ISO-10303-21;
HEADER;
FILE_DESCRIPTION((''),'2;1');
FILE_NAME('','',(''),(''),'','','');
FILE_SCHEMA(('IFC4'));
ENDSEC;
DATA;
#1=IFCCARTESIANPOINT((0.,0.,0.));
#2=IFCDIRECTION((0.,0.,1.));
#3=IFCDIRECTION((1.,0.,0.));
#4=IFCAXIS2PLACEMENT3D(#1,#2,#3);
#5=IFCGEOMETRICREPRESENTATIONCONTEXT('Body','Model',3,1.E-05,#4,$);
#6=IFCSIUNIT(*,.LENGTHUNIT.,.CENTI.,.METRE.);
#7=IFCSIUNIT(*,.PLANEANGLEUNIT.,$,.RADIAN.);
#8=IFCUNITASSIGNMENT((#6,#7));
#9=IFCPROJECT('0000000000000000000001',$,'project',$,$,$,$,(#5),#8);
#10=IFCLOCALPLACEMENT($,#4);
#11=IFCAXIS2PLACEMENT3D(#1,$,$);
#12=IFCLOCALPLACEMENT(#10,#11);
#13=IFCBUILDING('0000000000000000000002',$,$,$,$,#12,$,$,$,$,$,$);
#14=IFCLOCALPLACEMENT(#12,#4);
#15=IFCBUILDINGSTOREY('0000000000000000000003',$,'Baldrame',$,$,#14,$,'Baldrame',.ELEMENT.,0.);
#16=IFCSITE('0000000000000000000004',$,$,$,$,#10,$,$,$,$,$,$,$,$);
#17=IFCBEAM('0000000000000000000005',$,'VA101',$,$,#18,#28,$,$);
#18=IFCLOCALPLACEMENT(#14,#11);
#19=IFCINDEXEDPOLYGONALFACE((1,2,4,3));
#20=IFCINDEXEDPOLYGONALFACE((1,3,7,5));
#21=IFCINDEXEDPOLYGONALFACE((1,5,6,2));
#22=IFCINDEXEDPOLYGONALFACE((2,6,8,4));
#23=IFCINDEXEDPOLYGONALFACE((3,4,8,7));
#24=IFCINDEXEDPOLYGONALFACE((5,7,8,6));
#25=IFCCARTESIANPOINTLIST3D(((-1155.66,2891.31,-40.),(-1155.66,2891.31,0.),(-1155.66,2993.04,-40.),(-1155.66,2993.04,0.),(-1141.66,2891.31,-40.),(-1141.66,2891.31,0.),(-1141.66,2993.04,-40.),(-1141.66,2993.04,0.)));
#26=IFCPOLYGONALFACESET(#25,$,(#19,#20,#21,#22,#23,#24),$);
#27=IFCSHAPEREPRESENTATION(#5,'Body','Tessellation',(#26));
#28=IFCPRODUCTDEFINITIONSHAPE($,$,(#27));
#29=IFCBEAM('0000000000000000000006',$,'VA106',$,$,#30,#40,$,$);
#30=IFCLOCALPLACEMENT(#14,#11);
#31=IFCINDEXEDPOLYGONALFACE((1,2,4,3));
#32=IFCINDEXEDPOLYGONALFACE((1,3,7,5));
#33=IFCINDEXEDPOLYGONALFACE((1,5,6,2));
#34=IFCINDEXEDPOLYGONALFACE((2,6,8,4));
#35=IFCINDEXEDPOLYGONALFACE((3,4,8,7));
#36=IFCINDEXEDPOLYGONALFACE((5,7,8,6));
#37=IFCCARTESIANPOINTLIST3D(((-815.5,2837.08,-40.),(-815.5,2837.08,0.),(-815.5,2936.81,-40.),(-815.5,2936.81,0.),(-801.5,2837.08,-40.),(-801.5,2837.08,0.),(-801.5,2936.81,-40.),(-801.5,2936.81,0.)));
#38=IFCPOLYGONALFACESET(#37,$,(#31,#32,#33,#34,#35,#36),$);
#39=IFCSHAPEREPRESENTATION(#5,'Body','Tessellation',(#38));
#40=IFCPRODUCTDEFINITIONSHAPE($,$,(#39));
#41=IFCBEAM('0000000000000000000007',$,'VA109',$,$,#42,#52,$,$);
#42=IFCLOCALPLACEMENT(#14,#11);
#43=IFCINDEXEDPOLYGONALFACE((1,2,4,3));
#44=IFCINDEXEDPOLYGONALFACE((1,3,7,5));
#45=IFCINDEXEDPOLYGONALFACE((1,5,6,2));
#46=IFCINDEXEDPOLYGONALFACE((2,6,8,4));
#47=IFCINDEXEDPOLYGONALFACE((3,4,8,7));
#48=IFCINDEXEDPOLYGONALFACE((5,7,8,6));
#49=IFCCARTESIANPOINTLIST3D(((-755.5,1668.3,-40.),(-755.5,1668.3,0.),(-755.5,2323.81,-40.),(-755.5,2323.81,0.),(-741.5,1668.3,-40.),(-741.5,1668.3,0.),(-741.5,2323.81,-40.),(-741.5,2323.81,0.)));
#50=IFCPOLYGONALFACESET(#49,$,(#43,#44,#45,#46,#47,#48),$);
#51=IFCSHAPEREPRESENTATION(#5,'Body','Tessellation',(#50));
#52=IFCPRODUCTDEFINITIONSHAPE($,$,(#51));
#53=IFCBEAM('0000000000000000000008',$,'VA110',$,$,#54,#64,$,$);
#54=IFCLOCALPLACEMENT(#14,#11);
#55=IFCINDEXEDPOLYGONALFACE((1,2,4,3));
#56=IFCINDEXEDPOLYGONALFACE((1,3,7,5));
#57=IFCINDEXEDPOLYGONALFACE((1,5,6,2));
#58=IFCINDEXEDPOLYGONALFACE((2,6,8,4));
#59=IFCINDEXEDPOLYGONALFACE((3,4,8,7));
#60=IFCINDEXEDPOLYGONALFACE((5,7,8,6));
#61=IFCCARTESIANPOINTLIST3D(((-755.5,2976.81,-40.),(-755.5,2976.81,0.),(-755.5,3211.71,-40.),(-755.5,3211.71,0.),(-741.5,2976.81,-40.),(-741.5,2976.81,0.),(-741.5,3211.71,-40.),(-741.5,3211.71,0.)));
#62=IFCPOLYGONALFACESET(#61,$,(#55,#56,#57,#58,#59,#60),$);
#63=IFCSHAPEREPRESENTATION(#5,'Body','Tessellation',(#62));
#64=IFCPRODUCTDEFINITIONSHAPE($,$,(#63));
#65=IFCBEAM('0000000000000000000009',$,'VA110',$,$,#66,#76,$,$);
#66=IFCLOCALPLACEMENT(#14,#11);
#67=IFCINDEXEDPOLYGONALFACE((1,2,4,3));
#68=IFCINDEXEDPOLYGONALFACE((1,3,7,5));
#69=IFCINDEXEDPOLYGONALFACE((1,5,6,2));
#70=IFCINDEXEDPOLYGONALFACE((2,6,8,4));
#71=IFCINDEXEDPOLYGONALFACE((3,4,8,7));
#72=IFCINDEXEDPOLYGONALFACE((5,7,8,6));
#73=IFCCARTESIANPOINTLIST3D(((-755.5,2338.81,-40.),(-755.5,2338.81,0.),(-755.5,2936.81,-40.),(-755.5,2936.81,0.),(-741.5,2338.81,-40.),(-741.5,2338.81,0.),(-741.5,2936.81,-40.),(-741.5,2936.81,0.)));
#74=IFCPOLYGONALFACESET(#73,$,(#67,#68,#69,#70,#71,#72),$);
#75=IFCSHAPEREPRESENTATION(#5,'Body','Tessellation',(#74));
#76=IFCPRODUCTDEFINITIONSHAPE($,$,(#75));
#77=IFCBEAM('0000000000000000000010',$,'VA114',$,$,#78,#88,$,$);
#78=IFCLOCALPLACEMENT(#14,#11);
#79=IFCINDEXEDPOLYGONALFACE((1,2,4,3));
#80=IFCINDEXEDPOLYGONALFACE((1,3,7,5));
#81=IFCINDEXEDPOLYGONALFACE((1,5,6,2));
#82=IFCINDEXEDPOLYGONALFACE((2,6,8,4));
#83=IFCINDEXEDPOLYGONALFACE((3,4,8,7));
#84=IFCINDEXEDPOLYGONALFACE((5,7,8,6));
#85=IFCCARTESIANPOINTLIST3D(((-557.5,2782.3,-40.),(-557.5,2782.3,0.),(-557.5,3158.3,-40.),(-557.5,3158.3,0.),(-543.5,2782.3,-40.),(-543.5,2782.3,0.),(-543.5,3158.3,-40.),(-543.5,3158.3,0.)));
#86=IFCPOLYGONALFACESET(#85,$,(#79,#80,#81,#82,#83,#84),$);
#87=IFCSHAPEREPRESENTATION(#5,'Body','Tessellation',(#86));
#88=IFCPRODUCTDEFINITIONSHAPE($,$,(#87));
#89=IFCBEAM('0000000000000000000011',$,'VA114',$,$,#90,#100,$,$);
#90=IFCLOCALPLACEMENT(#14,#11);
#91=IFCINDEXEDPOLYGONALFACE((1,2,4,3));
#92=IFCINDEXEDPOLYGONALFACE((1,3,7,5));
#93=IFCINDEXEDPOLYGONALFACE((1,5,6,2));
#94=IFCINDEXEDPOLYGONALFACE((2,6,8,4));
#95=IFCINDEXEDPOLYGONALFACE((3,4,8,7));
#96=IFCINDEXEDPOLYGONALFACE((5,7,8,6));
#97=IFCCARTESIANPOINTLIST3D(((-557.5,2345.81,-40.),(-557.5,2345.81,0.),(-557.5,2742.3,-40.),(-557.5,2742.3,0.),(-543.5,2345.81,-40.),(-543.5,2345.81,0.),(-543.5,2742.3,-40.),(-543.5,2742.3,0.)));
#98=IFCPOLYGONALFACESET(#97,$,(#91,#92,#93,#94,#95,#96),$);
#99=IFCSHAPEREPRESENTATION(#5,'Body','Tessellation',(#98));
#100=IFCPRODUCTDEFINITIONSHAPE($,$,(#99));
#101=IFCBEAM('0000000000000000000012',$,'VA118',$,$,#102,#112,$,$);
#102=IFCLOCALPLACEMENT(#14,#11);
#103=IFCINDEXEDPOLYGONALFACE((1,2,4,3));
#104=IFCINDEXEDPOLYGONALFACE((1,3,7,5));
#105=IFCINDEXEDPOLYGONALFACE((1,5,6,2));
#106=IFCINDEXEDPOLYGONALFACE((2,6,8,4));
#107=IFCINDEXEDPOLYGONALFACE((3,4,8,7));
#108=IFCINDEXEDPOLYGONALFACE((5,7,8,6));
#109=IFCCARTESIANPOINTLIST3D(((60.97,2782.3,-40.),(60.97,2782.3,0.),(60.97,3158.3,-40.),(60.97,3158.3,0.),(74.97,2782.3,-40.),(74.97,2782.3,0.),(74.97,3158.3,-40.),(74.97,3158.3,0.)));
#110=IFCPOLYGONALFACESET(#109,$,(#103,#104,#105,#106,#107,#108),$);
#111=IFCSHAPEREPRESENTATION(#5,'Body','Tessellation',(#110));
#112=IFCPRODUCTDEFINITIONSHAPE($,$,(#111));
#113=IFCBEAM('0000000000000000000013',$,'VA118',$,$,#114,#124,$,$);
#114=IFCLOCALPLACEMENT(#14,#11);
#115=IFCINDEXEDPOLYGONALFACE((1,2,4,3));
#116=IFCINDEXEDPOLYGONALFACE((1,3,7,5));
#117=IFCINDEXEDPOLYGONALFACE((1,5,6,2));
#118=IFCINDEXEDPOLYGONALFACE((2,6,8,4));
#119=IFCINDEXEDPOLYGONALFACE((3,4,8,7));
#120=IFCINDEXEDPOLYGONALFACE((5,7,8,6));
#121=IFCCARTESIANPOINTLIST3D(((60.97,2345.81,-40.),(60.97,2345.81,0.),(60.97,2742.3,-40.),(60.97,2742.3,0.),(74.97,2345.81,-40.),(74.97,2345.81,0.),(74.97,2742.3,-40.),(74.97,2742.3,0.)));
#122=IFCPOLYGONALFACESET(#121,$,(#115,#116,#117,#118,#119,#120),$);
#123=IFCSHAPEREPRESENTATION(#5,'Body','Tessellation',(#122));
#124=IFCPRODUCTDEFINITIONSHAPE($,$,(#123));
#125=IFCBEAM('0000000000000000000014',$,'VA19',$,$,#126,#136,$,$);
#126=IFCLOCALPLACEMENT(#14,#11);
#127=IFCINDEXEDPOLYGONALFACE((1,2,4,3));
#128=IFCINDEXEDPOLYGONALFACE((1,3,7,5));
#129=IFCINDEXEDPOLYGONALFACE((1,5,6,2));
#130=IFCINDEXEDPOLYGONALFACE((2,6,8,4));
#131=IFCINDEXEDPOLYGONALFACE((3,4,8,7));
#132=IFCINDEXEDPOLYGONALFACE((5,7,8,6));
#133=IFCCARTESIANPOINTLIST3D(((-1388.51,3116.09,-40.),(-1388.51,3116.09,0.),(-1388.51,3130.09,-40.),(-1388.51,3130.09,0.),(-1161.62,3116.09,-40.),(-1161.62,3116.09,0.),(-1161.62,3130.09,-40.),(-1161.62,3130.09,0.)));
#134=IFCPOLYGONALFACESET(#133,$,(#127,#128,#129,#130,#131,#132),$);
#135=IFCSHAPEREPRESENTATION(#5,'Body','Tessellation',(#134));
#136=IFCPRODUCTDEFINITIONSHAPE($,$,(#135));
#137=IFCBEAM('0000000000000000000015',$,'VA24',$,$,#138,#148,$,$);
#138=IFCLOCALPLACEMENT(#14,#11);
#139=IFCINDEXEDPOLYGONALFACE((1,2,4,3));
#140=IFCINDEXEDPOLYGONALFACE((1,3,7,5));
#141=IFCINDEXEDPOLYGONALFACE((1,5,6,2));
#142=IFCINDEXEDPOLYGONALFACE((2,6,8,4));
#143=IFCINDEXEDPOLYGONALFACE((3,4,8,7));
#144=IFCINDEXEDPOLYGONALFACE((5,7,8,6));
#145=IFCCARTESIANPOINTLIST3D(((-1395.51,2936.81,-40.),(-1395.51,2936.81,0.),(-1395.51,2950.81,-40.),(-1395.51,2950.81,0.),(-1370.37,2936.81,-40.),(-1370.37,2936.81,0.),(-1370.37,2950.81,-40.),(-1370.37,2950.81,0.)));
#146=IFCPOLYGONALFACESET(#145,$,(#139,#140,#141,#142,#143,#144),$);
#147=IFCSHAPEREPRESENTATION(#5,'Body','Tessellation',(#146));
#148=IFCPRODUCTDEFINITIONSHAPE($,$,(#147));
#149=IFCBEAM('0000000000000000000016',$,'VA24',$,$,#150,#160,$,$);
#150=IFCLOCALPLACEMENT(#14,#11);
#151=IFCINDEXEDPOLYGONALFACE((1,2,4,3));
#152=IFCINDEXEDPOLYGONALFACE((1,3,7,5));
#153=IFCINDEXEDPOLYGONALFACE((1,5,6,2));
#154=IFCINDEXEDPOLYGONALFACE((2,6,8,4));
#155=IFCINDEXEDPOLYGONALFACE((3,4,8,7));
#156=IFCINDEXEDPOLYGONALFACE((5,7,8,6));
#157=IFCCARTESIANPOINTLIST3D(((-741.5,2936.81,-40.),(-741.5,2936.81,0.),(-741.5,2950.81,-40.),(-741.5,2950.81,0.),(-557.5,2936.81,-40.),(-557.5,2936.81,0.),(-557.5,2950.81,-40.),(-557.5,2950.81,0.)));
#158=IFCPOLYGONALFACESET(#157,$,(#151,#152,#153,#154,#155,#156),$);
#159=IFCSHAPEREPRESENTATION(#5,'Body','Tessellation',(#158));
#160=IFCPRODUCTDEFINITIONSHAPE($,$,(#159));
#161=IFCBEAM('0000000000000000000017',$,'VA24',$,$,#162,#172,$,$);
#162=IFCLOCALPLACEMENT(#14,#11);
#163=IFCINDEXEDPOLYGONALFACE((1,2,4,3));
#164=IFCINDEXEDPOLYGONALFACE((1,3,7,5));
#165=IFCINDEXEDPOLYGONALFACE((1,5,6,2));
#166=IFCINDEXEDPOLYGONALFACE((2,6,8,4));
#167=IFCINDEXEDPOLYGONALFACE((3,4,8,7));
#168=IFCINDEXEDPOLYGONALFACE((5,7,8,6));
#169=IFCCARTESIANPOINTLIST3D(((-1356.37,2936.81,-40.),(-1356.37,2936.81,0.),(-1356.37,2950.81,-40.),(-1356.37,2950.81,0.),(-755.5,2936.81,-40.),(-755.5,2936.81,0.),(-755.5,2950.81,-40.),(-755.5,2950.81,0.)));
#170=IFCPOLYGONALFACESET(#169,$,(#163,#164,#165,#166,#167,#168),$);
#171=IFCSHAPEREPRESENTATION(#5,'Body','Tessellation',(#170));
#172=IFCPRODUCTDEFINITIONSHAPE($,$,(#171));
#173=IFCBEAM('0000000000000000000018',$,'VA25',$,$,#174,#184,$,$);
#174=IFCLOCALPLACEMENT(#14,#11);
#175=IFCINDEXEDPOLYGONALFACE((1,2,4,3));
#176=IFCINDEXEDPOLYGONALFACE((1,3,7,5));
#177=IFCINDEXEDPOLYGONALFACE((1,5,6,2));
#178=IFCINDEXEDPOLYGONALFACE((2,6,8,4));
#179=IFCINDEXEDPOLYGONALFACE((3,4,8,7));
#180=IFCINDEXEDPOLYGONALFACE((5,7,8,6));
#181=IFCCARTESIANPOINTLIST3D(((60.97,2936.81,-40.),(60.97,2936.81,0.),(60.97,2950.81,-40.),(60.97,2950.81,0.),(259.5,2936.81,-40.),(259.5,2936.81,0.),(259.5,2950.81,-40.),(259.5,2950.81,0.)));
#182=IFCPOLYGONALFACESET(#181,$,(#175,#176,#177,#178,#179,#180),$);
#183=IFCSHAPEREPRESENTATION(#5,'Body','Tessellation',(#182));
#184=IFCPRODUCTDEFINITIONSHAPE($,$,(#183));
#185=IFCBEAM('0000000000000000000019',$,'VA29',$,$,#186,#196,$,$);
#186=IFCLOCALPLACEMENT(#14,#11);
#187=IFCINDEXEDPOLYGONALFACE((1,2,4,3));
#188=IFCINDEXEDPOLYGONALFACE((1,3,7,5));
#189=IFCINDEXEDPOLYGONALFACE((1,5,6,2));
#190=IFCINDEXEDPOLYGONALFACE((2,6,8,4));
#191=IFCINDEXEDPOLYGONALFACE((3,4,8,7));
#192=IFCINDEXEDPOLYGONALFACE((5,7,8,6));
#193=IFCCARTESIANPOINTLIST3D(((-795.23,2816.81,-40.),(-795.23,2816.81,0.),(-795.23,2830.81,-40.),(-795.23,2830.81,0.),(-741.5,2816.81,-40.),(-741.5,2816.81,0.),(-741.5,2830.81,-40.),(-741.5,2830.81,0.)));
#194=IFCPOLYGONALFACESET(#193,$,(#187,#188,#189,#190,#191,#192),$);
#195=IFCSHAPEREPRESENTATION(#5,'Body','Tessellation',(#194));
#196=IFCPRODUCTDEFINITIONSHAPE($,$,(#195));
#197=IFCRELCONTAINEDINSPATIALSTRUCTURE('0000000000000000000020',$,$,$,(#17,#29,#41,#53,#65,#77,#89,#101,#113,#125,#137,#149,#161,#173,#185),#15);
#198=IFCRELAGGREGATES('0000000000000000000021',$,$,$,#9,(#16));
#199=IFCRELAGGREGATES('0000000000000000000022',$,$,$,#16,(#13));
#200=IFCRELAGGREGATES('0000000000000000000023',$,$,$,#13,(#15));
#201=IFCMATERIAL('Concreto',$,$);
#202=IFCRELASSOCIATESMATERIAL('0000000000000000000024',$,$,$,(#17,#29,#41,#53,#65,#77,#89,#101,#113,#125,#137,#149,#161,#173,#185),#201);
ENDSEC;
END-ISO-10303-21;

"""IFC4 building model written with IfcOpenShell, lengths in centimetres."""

from ifc_helpers import new_model, si_unit, frame, origin, origin_with_axes, origin_2d_with_axis, place, context, project, spatial, rectangle, extrude, material, element, save


model = new_model("IFC4")

# Units and contexts
model_context = context("Model", 3, precision=1e-05, world=origin_with_axes(), identifier="Body")
ifc_project = project(units=[si_unit("LENGTHUNIT", "METRE", prefix="CENTI"), si_unit("PLANEANGLEUNIT", "RADIAN")], contexts=[model_context])

# Site, building, storey
site_placement = place(None, origin_with_axes())
site = spatial("IfcSite", under=ifc_project, at=site_placement)
building_placement = place(site_placement, origin())
building = spatial("IfcBuilding", under=site, at=building_placement)
storey_placement = place(building_placement, origin_with_axes())
storey = spatial("IfcBuildingStorey", under=building, at=storey_placement, Name="Baldrame", LongName="Baldrame", CompositionType="ELEMENT", Elevation=0.0)

# Shared definitions
ifc_material = material(Name="Concreto")

# Beams
beam_1_placement = place(storey_placement, frame((-1148.66, 2942.18, 0.0), z_axis=(0.0, 0.0, 1.0), x_axis=(1.0, 0.0, 0.0)))
element("IfcBeam", 1, at=beam_1_placement, inside=storey, material=ifc_material, Name="VA101", context=model_context, shape_type="SolidModel", body=[
    extrude(rectangle(XDim=14.0, YDim=40.0, at=origin_2d_with_axis()), frame((0.0, -50.87, -20.0), z_axis=(0.0, 1.0, 0.0), x_axis=(-1.0, 0.0, 0.0)), (0.0, 0.0, 1.0), 101.73),
])
beam_2_placement = place(storey_placement, frame((-808.5, 2886.94, 0.0), z_axis=(0.0, 0.0, 1.0), x_axis=(1.0, 0.0, 0.0)))
element("IfcBeam", 2, at=beam_2_placement, inside=storey, material=ifc_material, Name="VA106", context=model_context, shape_type="SolidModel", body=[
    extrude(rectangle(XDim=14.0, YDim=40.0, at=origin_2d_with_axis()), frame((0.0, -49.87, -20.0), z_axis=(0.0, 1.0, 0.0), x_axis=(-1.0, 0.0, 0.0)), (0.0, 0.0, 1.0), 99.73),
])
beam_3_placement = place(storey_placement, frame((-748.5, 1996.06, 0.0), z_axis=(0.0, 0.0, 1.0), x_axis=(1.0, 0.0, 0.0)))
element("IfcBeam", 3, at=beam_3_placement, inside=storey, material=ifc_material, Name="VA109", context=model_context, shape_type="SolidModel", body=[
    extrude(rectangle(XDim=14.0, YDim=40.0, at=origin_2d_with_axis()), frame((0.0, -327.75, -20.0), z_axis=(0.0, 1.0, 0.0), x_axis=(-1.0, 0.0, 0.0)), (0.0, 0.0, 1.0), 655.51),
])
beam_4_placement = place(storey_placement, frame((-748.5, 3094.26, 0.0), z_axis=(0.0, 0.0, 1.0), x_axis=(1.0, 0.0, 0.0)))
element("IfcBeam", 4, at=beam_4_placement, inside=storey, material=ifc_material, Name="VA110", context=model_context, shape_type="SolidModel", body=[
    extrude(rectangle(XDim=14.0, YDim=40.0, at=origin_2d_with_axis()), frame((0.0, -117.45, -20.0), z_axis=(0.0, 1.0, 0.0), x_axis=(-1.0, 0.0, 0.0)), (0.0, 0.0, 1.0), 234.9),
])
beam_5_placement = place(storey_placement, frame((-748.5, 2637.81, 0.0), z_axis=(0.0, 0.0, 1.0), x_axis=(1.0, 0.0, 0.0)))
element("IfcBeam", 5, at=beam_5_placement, inside=storey, material=ifc_material, Name="VA110", context=model_context, shape_type="SolidModel", body=[
    extrude(rectangle(XDim=14.0, YDim=40.0, at=origin_2d_with_axis()), frame((0.0, -299.0, -20.0), z_axis=(0.0, 1.0, 0.0), x_axis=(-1.0, 0.0, 0.0)), (0.0, 0.0, 1.0), 598.0),
])
beam_6_placement = place(storey_placement, frame((-550.5, 2970.3, 0.0), z_axis=(0.0, 0.0, 1.0), x_axis=(1.0, 0.0, 0.0)))
element("IfcBeam", 6, at=beam_6_placement, inside=storey, material=ifc_material, Name="VA114", context=model_context, shape_type="SolidModel", body=[
    extrude(rectangle(XDim=14.0, YDim=40.0, at=origin_2d_with_axis()), frame((0.0, -188.0, -20.0), z_axis=(0.0, 1.0, 0.0), x_axis=(-1.0, 0.0, 0.0)), (0.0, 0.0, 1.0), 376.0),
])
beam_7_placement = place(storey_placement, frame((-550.5, 2544.05, 0.0), z_axis=(0.0, 0.0, 1.0), x_axis=(1.0, 0.0, 0.0)))
element("IfcBeam", 7, at=beam_7_placement, inside=storey, material=ifc_material, Name="VA114", context=model_context, shape_type="SolidModel", body=[
    extrude(rectangle(XDim=14.0, YDim=40.0, at=origin_2d_with_axis()), frame((0.0, -198.25, -20.0), z_axis=(0.0, 1.0, 0.0), x_axis=(-1.0, 0.0, 0.0)), (0.0, 0.0, 1.0), 396.49),
])
beam_8_placement = place(storey_placement, frame((67.97, 2970.3, 0.0), z_axis=(0.0, 0.0, 1.0), x_axis=(1.0, 0.0, 0.0)))
element("IfcBeam", 8, at=beam_8_placement, inside=storey, material=ifc_material, Name="VA118", context=model_context, shape_type="SolidModel", body=[
    extrude(rectangle(XDim=14.0, YDim=40.0, at=origin_2d_with_axis()), frame((0.0, -188.0, -20.0), z_axis=(0.0, 1.0, 0.0), x_axis=(-1.0, 0.0, 0.0)), (0.0, 0.0, 1.0), 376.0),
])
beam_9_placement = place(storey_placement, frame((67.97, 2544.05, 0.0), z_axis=(0.0, 0.0, 1.0), x_axis=(1.0, 0.0, 0.0)))
element("IfcBeam", 9, at=beam_9_placement, inside=storey, material=ifc_material, Name="VA118", context=model_context, shape_type="SolidModel", body=[
    extrude(rectangle(XDim=14.0, YDim=40.0, at=origin_2d_with_axis()), frame((0.0, -198.25, -20.0), z_axis=(0.0, 1.0, 0.0), x_axis=(-1.0, 0.0, 0.0)), (0.0, 0.0, 1.0), 396.49),
])
beam_10_placement = place(storey_placement, frame((-1275.06, 3123.09, 0.0), z_axis=(0.0, 0.0, 1.0), x_axis=(1.0, 0.0, 0.0)))
element("IfcBeam", 10, at=beam_10_placement, inside=storey, material=ifc_material, Name="VA19", context=model_context, shape_type="SolidModel", body=[
    extrude(rectangle(XDim=14.0, YDim=40.0, at=origin_2d_with_axis()), frame((-113.45, 0.0, -20.0), z_axis=(1.0, 0.0, 0.0), x_axis=(0.0, 1.0, 0.0)), (0.0, 0.0, 1.0), 226.89),
])
beam_11_placement = place(storey_placement, frame((-1382.94, 2943.81, 0.0), z_axis=(0.0, 0.0, 1.0), x_axis=(1.0, 0.0, 0.0)))
element("IfcBeam", 11, at=beam_11_placement, inside=storey, material=ifc_material, Name="VA24", context=model_context, shape_type="SolidModel", body=[
    extrude(rectangle(XDim=14.0, YDim=40.0, at=origin_2d_with_axis()), frame((-12.57, 0.0, -20.0), z_axis=(1.0, 0.0, 0.0), x_axis=(0.0, 1.0, 0.0)), (0.0, 0.0, 1.0), 25.14),
])
beam_12_placement = place(storey_placement, frame((-649.5, 2943.81, 0.0), z_axis=(0.0, 0.0, 1.0), x_axis=(1.0, 0.0, 0.0)))
element("IfcBeam", 12, at=beam_12_placement, inside=storey, material=ifc_material, Name="VA24", context=model_context, shape_type="SolidModel", body=[
    extrude(rectangle(XDim=14.0, YDim=40.0, at=origin_2d_with_axis()), frame((-92.0, 0.0, -20.0), z_axis=(1.0, 0.0, 0.0), x_axis=(0.0, 1.0, 0.0)), (0.0, 0.0, 1.0), 184.0),
])
beam_13_placement = place(storey_placement, frame((-1055.93, 2943.81, 0.0), z_axis=(0.0, 0.0, 1.0), x_axis=(1.0, 0.0, 0.0)))
element("IfcBeam", 13, at=beam_13_placement, inside=storey, material=ifc_material, Name="VA24", context=model_context, shape_type="SolidModel", body=[
    extrude(rectangle(XDim=14.0, YDim=40.0, at=origin_2d_with_axis()), frame((-300.44, 0.0, -20.0), z_axis=(1.0, 0.0, 0.0), x_axis=(0.0, 1.0, 0.0)), (0.0, 0.0, 1.0), 600.87),
])
beam_14_placement = place(storey_placement, frame((160.24, 2943.81, 0.0), z_axis=(0.0, 0.0, 1.0), x_axis=(1.0, 0.0, 0.0)))
element("IfcBeam", 14, at=beam_14_placement, inside=storey, material=ifc_material, Name="VA25", context=model_context, shape_type="SolidModel", body=[
    extrude(rectangle(XDim=14.0, YDim=40.0, at=origin_2d_with_axis()), frame((-99.27, 0.0, -20.0), z_axis=(1.0, 0.0, 0.0), x_axis=(0.0, 1.0, 0.0)), (0.0, 0.0, 1.0), 198.53),
])
beam_15_placement = place(storey_placement, frame((-768.37, 2823.81, 0.0), z_axis=(0.0, 0.0, 1.0), x_axis=(1.0, 0.0, 0.0)))
element("IfcBeam", 15, at=beam_15_placement, inside=storey, material=ifc_material, Name="VA29", context=model_context, shape_type="SolidModel", body=[
    extrude(rectangle(XDim=14.0, YDim=40.0, at=origin_2d_with_axis()), frame((-26.87, 0.0, -20.0), z_axis=(1.0, 0.0, 0.0), x_axis=(0.0, 1.0, 0.0)), (0.0, 0.0, 1.0), 53.73),
])

save(model, "model.ifc")
